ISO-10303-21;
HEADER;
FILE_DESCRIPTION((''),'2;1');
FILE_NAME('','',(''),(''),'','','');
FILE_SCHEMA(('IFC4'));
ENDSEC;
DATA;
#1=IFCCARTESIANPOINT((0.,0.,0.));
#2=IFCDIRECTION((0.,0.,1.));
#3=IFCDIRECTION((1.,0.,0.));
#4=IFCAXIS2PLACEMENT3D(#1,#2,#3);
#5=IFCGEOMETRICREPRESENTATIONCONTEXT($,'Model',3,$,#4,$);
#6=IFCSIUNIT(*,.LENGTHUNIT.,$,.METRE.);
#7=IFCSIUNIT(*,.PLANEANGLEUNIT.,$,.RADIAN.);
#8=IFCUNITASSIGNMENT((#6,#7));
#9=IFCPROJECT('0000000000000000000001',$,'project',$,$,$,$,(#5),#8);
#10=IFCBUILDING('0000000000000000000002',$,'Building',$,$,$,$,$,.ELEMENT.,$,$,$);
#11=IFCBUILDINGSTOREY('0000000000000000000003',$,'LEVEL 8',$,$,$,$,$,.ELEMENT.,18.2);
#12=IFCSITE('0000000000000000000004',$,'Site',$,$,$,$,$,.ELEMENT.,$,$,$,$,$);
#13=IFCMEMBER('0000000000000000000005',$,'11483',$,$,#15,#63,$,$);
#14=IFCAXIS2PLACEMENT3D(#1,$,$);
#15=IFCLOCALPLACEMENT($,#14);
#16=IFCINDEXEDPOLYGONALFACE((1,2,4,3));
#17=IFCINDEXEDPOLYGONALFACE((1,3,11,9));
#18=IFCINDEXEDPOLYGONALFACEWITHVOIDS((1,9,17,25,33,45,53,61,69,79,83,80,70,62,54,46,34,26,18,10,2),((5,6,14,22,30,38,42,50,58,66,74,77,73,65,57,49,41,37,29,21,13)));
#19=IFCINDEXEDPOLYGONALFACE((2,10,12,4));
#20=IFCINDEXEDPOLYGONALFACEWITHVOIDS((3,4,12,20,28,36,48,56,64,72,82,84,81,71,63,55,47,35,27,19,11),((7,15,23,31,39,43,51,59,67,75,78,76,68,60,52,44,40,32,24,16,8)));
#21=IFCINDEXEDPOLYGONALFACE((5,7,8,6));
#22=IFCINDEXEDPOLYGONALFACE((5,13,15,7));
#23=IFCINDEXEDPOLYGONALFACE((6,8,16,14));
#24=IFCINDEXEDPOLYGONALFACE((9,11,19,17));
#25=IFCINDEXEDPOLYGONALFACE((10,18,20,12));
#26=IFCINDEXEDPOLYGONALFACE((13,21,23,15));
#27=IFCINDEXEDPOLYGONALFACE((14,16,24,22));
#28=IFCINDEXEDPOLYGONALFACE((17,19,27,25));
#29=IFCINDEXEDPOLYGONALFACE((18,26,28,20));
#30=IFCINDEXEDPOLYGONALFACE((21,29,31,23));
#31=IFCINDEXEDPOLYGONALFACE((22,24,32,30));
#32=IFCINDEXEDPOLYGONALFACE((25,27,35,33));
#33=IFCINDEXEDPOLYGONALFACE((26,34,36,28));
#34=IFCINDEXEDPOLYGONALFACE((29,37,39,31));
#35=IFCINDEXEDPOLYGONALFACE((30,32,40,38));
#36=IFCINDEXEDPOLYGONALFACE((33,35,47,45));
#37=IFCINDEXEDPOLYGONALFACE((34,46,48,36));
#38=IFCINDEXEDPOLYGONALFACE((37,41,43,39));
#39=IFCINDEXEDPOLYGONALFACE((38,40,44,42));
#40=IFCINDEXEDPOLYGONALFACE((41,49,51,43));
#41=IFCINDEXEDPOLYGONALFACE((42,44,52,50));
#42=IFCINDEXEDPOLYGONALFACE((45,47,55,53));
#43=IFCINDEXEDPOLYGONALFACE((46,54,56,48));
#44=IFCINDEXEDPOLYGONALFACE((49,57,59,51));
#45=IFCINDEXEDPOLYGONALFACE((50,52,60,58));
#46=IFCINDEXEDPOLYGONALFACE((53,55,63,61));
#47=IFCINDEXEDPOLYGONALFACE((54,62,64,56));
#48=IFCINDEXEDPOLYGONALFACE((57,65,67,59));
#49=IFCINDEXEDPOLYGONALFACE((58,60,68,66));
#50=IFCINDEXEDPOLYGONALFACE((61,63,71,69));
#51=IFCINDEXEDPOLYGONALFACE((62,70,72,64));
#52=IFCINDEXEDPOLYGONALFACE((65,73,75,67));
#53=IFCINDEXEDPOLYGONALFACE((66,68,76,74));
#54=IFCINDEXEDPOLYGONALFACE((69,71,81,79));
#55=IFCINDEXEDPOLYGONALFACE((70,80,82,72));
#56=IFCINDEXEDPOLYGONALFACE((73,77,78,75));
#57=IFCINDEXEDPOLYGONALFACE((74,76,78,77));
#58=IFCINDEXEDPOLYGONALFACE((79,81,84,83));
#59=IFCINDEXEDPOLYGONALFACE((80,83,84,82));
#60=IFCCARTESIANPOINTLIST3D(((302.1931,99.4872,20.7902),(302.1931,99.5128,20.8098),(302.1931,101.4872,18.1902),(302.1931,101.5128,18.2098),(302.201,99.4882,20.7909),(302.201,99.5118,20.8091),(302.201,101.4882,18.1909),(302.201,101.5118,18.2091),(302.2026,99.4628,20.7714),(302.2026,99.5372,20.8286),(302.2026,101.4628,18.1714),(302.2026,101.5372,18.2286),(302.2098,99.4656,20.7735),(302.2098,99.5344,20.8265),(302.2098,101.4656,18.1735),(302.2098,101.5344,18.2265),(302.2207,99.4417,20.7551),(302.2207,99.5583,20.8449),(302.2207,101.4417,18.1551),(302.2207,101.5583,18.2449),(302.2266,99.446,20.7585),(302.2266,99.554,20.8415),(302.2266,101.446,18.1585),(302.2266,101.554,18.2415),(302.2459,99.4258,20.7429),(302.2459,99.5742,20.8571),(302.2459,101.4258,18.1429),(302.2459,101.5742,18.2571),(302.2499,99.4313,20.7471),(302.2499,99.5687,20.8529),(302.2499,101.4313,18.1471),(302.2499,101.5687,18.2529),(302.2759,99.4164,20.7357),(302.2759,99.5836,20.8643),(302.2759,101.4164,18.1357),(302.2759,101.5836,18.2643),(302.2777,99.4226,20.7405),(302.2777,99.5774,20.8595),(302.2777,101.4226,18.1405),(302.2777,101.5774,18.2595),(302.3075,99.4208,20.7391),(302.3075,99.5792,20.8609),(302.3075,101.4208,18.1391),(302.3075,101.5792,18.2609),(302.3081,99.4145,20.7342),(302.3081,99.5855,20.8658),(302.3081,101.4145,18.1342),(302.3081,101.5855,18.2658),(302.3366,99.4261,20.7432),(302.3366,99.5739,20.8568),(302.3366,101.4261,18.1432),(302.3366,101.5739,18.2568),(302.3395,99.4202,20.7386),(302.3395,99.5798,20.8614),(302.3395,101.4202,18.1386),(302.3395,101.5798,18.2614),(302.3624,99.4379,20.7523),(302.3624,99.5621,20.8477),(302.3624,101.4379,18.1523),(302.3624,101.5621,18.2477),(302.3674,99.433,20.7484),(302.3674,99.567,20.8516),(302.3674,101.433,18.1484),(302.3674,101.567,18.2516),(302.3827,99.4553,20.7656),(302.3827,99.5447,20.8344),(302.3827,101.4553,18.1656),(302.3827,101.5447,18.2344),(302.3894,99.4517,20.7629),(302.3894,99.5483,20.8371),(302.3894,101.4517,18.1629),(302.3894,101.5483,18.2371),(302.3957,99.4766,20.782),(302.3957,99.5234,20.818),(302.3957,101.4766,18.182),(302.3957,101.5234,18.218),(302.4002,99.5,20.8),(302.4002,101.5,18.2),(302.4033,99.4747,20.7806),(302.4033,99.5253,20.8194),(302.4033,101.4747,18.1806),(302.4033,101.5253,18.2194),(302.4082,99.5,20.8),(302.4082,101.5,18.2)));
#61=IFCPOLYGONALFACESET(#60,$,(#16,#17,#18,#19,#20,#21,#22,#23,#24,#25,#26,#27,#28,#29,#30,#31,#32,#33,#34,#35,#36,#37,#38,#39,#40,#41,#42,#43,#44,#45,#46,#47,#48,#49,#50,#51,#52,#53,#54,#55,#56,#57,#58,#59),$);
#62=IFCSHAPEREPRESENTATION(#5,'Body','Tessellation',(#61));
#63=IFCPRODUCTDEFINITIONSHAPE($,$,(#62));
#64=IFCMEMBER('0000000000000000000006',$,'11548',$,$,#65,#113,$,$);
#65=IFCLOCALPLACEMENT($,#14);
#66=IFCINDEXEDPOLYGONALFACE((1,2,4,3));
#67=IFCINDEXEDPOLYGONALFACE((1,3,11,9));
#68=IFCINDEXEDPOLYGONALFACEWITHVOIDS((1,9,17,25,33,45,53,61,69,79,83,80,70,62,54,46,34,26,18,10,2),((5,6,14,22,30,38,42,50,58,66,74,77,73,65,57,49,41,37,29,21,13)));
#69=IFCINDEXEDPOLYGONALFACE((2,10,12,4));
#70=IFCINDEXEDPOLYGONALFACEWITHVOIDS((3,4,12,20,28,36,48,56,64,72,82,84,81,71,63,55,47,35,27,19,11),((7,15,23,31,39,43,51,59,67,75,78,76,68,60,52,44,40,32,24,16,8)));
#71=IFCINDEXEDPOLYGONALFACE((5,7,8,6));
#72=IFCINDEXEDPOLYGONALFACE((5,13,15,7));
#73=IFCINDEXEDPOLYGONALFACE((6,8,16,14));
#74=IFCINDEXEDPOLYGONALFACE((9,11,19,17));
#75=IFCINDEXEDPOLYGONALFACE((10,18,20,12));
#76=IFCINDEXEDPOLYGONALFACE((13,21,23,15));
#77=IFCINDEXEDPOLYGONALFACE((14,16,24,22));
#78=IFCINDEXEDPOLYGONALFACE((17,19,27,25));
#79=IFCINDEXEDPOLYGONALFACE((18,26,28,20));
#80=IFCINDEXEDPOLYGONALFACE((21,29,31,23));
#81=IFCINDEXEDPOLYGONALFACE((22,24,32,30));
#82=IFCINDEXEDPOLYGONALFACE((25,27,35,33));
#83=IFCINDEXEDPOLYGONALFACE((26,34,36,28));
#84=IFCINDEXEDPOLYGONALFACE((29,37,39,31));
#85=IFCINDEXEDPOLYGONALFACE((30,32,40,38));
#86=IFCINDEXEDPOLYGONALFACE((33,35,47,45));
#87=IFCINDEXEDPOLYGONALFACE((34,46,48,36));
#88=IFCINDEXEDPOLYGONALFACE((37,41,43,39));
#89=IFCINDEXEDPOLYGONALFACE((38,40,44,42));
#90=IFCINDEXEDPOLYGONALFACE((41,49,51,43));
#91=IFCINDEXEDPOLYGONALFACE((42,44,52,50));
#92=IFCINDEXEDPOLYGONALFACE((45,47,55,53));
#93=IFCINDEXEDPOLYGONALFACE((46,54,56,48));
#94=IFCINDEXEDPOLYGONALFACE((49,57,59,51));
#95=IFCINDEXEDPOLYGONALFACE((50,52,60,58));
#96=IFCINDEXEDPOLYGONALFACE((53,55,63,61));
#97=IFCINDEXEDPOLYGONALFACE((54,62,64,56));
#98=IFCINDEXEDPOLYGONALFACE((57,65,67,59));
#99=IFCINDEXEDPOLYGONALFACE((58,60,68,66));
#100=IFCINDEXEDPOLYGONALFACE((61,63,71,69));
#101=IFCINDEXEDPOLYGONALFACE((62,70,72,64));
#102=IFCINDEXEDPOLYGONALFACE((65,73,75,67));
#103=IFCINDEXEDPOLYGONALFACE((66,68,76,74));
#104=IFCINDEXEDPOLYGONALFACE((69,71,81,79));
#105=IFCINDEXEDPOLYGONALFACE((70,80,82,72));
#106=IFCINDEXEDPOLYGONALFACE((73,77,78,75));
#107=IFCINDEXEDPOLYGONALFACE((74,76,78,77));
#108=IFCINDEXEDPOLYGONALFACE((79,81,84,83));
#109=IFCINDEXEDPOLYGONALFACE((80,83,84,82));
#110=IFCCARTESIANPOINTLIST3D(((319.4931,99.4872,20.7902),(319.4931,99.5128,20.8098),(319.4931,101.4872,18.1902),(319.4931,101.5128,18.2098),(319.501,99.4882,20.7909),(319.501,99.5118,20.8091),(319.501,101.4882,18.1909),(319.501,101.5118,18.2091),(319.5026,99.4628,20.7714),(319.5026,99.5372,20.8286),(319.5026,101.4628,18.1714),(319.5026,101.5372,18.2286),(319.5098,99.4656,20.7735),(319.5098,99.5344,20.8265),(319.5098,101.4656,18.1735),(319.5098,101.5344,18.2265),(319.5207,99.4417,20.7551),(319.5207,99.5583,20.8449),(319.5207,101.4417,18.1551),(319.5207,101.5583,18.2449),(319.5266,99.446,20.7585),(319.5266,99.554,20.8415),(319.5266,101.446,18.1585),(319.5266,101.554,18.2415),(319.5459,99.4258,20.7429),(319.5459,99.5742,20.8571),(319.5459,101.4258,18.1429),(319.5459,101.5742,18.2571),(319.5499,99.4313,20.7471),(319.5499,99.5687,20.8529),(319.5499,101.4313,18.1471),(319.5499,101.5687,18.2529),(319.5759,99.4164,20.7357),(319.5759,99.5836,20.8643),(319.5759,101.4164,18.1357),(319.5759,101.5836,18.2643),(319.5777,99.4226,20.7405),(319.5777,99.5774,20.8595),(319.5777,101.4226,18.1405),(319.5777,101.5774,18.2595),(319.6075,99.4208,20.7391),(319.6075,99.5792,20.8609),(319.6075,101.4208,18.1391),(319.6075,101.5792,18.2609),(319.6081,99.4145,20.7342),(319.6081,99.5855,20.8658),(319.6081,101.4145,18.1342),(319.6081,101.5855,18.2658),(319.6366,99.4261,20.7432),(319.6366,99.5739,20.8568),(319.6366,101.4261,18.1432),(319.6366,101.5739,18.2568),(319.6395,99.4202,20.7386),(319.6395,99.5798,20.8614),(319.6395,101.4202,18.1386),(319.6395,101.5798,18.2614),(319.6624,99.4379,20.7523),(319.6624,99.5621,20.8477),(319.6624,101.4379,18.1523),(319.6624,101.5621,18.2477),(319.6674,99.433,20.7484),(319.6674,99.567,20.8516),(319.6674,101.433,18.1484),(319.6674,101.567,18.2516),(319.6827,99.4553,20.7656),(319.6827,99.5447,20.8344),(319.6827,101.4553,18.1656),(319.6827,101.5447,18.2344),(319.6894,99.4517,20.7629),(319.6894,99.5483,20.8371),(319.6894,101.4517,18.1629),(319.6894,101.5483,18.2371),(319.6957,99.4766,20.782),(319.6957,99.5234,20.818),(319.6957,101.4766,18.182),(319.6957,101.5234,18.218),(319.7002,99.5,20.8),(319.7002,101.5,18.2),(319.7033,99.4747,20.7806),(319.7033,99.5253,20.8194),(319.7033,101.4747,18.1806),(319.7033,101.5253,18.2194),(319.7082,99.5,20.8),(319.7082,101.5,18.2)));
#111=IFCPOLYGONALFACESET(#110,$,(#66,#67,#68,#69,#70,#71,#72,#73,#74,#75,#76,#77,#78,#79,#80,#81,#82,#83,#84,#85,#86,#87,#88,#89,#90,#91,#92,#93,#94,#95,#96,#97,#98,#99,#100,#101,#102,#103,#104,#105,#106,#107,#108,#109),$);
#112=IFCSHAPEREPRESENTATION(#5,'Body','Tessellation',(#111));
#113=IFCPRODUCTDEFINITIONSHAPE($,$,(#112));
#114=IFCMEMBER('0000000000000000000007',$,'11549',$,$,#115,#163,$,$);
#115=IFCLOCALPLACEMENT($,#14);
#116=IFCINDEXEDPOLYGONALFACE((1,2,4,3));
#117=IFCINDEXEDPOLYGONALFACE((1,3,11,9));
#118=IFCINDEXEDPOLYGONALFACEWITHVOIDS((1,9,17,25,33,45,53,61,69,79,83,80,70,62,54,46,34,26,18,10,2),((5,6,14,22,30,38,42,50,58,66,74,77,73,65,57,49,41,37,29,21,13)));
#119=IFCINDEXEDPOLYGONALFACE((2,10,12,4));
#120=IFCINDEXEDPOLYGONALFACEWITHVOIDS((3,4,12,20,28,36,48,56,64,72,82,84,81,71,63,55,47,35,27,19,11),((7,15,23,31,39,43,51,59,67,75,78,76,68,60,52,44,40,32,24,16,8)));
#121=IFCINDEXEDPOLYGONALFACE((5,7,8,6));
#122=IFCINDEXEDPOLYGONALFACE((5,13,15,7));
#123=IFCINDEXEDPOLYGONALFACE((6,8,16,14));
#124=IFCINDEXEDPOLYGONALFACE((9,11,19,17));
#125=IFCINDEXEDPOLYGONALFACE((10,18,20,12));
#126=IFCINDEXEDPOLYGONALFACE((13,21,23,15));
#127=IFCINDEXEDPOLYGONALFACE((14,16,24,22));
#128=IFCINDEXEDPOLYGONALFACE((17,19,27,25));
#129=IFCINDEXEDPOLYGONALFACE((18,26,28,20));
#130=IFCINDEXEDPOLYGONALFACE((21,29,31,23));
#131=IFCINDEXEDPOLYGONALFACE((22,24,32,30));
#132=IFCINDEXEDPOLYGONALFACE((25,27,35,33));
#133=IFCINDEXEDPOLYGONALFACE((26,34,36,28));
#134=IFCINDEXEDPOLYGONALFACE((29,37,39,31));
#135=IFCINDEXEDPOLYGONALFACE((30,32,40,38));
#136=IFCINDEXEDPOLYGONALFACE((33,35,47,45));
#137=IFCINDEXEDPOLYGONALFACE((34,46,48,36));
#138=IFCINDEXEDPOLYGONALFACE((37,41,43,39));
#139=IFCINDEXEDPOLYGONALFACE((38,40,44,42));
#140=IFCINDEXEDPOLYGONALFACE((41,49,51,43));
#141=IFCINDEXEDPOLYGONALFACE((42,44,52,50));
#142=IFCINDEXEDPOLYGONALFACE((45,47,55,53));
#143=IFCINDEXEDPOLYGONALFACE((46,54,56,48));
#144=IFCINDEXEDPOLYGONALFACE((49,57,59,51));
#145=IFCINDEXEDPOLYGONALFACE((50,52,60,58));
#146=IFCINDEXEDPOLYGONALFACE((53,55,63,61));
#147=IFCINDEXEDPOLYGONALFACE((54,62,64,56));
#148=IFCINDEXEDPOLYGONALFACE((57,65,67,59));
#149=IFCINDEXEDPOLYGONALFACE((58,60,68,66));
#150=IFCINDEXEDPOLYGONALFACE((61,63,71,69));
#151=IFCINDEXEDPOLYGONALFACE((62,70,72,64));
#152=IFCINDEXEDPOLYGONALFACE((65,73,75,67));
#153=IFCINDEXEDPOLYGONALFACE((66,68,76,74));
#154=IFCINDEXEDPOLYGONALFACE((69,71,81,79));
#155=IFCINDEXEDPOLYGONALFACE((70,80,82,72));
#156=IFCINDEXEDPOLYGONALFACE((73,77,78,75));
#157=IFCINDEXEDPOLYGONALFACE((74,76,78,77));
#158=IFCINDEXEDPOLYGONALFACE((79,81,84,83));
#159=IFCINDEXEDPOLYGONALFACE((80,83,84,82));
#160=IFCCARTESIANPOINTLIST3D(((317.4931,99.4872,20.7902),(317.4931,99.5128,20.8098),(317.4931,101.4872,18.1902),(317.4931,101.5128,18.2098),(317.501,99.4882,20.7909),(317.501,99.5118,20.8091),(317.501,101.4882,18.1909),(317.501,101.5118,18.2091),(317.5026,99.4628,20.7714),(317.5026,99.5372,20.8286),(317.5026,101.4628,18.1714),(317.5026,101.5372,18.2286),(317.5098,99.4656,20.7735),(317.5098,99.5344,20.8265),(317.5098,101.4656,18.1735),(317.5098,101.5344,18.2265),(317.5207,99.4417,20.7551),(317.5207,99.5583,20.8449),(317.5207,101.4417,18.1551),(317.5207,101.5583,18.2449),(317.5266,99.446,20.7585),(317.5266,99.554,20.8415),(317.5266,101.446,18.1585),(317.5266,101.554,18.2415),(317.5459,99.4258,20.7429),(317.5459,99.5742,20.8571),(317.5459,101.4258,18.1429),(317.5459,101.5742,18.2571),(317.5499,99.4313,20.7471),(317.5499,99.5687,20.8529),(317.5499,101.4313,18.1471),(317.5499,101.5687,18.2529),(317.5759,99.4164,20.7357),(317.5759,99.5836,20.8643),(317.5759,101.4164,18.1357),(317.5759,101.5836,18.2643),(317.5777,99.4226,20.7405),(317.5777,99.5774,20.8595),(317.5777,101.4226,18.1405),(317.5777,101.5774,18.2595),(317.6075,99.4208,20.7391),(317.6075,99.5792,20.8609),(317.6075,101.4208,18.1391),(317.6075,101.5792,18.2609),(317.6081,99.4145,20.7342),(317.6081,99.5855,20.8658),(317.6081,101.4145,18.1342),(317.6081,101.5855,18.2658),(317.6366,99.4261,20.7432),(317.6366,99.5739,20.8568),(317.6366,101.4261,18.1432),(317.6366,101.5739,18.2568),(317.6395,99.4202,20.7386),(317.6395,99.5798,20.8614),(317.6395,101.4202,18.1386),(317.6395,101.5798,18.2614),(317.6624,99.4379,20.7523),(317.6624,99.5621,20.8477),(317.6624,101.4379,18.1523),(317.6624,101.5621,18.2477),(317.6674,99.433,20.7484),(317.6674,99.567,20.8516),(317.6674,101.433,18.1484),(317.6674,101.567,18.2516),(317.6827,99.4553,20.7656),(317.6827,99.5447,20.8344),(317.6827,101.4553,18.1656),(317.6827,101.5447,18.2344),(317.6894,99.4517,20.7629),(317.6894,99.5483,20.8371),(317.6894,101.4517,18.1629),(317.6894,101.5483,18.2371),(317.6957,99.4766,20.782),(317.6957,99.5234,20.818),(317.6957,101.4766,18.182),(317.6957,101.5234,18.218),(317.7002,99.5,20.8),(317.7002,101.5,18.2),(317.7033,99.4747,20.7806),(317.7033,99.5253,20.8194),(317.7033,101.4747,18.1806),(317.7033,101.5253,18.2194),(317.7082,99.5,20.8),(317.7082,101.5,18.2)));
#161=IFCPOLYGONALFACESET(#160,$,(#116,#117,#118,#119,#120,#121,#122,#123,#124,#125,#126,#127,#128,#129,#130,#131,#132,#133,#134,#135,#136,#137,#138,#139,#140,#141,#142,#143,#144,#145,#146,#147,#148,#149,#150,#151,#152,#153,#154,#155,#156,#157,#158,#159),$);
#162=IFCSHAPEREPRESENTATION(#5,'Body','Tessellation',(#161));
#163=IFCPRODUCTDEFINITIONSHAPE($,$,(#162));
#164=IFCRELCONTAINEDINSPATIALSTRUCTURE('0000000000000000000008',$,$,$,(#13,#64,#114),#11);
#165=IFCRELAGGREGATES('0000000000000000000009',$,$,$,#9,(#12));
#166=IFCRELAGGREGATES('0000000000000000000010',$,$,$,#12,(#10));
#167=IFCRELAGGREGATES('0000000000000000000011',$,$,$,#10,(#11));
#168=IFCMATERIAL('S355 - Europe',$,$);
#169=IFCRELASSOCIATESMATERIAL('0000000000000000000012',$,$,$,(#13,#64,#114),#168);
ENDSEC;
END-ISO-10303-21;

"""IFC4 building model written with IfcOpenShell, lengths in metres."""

from ifc_helpers import new_model, si_unit, frame, origin_with_axes, origin_2d_with_axis, place, context, project, spatial, hollow_circle, extrude, material, material_profile, profile_set, profile_usage, element, save


model = new_model("IFC4")

# Units and contexts
model_context = context("Model", 3, world=origin_with_axes())
ifc_project = project(units=[si_unit("LENGTHUNIT", "METRE"), si_unit("PLANEANGLEUNIT", "RADIAN")], contexts=[model_context])

# Site, building, storey
site = spatial("IfcSite", under=ifc_project, Name="Site", CompositionType="ELEMENT")
building = spatial("IfcBuilding", under=site, Name="Building", CompositionType="ELEMENT")
storey = spatial("IfcBuildingStorey", under=building, Name="LEVEL 8", CompositionType="ELEMENT", Elevation=18.2)

# Shared definitions
ifc_material = material(Name="S355 - Europe")

# Members
ifc_material_profile_1 = material_profile(ifc_material, hollow_circle(Radius=0.1081, WallThickness=0.008, at=origin_2d_with_axis()))
ifc_profile_set_1 = profile_set([ifc_material_profile_1])
ifc_profile_usage_1 = profile_usage(ifc_profile_set_1, cardinal=10)
member_1_placement = place(None, frame((302.3, 101.5, 18.2), z_axis=(0.0, -0.609711, 0.792624), x_axis=(1.0, 0.0, 0.0)))
element("IfcMember", 1, at=member_1_placement, inside=storey, material=ifc_profile_usage_1, Name="11483", context=model_context, shape_type="SweptSolid", body=[
    extrude(hollow_circle(Radius=0.1081, WallThickness=0.008, at=origin_2d_with_axis()), origin_with_axes(), (0.0, 0.0, 1.0), 3.2802),
])
ifc_material_profile_2 = material_profile(ifc_material, hollow_circle(Radius=0.1081, WallThickness=0.008, at=origin_2d_with_axis()))
ifc_profile_set_2 = profile_set([ifc_material_profile_2])
ifc_profile_usage_2 = profile_usage(ifc_profile_set_2, cardinal=10)
member_2_placement = place(None, frame((319.6, 101.5, 18.2), z_axis=(0.0, -0.609711, 0.792624), x_axis=(1.0, 0.0, 0.0)))
element("IfcMember", 2, at=member_2_placement, inside=storey, material=ifc_profile_usage_2, Name="11548", context=model_context, shape_type="SweptSolid", body=[
    extrude(hollow_circle(Radius=0.1081, WallThickness=0.008, at=origin_2d_with_axis()), origin_with_axes(), (0.0, 0.0, 1.0), 3.2802),
])
ifc_material_profile_3 = material_profile(ifc_material, hollow_circle(Radius=0.1081, WallThickness=0.008, at=origin_2d_with_axis()))
ifc_profile_set_3 = profile_set([ifc_material_profile_3])
ifc_profile_usage_3 = profile_usage(ifc_profile_set_3, cardinal=10)
member_3_placement = place(None, frame((317.6, 101.5, 18.2), z_axis=(0.0, -0.609711, 0.792624), x_axis=(1.0, 0.0, 0.0)))
element("IfcMember", 3, at=member_3_placement, inside=storey, material=ifc_profile_usage_3, Name="11549", context=model_context, shape_type="SweptSolid", body=[
    extrude(hollow_circle(Radius=0.1081, WallThickness=0.008, at=origin_2d_with_axis()), origin_with_axes(), (0.0, 0.0, 1.0), 3.2802),
])

save(model, "model.ifc")
